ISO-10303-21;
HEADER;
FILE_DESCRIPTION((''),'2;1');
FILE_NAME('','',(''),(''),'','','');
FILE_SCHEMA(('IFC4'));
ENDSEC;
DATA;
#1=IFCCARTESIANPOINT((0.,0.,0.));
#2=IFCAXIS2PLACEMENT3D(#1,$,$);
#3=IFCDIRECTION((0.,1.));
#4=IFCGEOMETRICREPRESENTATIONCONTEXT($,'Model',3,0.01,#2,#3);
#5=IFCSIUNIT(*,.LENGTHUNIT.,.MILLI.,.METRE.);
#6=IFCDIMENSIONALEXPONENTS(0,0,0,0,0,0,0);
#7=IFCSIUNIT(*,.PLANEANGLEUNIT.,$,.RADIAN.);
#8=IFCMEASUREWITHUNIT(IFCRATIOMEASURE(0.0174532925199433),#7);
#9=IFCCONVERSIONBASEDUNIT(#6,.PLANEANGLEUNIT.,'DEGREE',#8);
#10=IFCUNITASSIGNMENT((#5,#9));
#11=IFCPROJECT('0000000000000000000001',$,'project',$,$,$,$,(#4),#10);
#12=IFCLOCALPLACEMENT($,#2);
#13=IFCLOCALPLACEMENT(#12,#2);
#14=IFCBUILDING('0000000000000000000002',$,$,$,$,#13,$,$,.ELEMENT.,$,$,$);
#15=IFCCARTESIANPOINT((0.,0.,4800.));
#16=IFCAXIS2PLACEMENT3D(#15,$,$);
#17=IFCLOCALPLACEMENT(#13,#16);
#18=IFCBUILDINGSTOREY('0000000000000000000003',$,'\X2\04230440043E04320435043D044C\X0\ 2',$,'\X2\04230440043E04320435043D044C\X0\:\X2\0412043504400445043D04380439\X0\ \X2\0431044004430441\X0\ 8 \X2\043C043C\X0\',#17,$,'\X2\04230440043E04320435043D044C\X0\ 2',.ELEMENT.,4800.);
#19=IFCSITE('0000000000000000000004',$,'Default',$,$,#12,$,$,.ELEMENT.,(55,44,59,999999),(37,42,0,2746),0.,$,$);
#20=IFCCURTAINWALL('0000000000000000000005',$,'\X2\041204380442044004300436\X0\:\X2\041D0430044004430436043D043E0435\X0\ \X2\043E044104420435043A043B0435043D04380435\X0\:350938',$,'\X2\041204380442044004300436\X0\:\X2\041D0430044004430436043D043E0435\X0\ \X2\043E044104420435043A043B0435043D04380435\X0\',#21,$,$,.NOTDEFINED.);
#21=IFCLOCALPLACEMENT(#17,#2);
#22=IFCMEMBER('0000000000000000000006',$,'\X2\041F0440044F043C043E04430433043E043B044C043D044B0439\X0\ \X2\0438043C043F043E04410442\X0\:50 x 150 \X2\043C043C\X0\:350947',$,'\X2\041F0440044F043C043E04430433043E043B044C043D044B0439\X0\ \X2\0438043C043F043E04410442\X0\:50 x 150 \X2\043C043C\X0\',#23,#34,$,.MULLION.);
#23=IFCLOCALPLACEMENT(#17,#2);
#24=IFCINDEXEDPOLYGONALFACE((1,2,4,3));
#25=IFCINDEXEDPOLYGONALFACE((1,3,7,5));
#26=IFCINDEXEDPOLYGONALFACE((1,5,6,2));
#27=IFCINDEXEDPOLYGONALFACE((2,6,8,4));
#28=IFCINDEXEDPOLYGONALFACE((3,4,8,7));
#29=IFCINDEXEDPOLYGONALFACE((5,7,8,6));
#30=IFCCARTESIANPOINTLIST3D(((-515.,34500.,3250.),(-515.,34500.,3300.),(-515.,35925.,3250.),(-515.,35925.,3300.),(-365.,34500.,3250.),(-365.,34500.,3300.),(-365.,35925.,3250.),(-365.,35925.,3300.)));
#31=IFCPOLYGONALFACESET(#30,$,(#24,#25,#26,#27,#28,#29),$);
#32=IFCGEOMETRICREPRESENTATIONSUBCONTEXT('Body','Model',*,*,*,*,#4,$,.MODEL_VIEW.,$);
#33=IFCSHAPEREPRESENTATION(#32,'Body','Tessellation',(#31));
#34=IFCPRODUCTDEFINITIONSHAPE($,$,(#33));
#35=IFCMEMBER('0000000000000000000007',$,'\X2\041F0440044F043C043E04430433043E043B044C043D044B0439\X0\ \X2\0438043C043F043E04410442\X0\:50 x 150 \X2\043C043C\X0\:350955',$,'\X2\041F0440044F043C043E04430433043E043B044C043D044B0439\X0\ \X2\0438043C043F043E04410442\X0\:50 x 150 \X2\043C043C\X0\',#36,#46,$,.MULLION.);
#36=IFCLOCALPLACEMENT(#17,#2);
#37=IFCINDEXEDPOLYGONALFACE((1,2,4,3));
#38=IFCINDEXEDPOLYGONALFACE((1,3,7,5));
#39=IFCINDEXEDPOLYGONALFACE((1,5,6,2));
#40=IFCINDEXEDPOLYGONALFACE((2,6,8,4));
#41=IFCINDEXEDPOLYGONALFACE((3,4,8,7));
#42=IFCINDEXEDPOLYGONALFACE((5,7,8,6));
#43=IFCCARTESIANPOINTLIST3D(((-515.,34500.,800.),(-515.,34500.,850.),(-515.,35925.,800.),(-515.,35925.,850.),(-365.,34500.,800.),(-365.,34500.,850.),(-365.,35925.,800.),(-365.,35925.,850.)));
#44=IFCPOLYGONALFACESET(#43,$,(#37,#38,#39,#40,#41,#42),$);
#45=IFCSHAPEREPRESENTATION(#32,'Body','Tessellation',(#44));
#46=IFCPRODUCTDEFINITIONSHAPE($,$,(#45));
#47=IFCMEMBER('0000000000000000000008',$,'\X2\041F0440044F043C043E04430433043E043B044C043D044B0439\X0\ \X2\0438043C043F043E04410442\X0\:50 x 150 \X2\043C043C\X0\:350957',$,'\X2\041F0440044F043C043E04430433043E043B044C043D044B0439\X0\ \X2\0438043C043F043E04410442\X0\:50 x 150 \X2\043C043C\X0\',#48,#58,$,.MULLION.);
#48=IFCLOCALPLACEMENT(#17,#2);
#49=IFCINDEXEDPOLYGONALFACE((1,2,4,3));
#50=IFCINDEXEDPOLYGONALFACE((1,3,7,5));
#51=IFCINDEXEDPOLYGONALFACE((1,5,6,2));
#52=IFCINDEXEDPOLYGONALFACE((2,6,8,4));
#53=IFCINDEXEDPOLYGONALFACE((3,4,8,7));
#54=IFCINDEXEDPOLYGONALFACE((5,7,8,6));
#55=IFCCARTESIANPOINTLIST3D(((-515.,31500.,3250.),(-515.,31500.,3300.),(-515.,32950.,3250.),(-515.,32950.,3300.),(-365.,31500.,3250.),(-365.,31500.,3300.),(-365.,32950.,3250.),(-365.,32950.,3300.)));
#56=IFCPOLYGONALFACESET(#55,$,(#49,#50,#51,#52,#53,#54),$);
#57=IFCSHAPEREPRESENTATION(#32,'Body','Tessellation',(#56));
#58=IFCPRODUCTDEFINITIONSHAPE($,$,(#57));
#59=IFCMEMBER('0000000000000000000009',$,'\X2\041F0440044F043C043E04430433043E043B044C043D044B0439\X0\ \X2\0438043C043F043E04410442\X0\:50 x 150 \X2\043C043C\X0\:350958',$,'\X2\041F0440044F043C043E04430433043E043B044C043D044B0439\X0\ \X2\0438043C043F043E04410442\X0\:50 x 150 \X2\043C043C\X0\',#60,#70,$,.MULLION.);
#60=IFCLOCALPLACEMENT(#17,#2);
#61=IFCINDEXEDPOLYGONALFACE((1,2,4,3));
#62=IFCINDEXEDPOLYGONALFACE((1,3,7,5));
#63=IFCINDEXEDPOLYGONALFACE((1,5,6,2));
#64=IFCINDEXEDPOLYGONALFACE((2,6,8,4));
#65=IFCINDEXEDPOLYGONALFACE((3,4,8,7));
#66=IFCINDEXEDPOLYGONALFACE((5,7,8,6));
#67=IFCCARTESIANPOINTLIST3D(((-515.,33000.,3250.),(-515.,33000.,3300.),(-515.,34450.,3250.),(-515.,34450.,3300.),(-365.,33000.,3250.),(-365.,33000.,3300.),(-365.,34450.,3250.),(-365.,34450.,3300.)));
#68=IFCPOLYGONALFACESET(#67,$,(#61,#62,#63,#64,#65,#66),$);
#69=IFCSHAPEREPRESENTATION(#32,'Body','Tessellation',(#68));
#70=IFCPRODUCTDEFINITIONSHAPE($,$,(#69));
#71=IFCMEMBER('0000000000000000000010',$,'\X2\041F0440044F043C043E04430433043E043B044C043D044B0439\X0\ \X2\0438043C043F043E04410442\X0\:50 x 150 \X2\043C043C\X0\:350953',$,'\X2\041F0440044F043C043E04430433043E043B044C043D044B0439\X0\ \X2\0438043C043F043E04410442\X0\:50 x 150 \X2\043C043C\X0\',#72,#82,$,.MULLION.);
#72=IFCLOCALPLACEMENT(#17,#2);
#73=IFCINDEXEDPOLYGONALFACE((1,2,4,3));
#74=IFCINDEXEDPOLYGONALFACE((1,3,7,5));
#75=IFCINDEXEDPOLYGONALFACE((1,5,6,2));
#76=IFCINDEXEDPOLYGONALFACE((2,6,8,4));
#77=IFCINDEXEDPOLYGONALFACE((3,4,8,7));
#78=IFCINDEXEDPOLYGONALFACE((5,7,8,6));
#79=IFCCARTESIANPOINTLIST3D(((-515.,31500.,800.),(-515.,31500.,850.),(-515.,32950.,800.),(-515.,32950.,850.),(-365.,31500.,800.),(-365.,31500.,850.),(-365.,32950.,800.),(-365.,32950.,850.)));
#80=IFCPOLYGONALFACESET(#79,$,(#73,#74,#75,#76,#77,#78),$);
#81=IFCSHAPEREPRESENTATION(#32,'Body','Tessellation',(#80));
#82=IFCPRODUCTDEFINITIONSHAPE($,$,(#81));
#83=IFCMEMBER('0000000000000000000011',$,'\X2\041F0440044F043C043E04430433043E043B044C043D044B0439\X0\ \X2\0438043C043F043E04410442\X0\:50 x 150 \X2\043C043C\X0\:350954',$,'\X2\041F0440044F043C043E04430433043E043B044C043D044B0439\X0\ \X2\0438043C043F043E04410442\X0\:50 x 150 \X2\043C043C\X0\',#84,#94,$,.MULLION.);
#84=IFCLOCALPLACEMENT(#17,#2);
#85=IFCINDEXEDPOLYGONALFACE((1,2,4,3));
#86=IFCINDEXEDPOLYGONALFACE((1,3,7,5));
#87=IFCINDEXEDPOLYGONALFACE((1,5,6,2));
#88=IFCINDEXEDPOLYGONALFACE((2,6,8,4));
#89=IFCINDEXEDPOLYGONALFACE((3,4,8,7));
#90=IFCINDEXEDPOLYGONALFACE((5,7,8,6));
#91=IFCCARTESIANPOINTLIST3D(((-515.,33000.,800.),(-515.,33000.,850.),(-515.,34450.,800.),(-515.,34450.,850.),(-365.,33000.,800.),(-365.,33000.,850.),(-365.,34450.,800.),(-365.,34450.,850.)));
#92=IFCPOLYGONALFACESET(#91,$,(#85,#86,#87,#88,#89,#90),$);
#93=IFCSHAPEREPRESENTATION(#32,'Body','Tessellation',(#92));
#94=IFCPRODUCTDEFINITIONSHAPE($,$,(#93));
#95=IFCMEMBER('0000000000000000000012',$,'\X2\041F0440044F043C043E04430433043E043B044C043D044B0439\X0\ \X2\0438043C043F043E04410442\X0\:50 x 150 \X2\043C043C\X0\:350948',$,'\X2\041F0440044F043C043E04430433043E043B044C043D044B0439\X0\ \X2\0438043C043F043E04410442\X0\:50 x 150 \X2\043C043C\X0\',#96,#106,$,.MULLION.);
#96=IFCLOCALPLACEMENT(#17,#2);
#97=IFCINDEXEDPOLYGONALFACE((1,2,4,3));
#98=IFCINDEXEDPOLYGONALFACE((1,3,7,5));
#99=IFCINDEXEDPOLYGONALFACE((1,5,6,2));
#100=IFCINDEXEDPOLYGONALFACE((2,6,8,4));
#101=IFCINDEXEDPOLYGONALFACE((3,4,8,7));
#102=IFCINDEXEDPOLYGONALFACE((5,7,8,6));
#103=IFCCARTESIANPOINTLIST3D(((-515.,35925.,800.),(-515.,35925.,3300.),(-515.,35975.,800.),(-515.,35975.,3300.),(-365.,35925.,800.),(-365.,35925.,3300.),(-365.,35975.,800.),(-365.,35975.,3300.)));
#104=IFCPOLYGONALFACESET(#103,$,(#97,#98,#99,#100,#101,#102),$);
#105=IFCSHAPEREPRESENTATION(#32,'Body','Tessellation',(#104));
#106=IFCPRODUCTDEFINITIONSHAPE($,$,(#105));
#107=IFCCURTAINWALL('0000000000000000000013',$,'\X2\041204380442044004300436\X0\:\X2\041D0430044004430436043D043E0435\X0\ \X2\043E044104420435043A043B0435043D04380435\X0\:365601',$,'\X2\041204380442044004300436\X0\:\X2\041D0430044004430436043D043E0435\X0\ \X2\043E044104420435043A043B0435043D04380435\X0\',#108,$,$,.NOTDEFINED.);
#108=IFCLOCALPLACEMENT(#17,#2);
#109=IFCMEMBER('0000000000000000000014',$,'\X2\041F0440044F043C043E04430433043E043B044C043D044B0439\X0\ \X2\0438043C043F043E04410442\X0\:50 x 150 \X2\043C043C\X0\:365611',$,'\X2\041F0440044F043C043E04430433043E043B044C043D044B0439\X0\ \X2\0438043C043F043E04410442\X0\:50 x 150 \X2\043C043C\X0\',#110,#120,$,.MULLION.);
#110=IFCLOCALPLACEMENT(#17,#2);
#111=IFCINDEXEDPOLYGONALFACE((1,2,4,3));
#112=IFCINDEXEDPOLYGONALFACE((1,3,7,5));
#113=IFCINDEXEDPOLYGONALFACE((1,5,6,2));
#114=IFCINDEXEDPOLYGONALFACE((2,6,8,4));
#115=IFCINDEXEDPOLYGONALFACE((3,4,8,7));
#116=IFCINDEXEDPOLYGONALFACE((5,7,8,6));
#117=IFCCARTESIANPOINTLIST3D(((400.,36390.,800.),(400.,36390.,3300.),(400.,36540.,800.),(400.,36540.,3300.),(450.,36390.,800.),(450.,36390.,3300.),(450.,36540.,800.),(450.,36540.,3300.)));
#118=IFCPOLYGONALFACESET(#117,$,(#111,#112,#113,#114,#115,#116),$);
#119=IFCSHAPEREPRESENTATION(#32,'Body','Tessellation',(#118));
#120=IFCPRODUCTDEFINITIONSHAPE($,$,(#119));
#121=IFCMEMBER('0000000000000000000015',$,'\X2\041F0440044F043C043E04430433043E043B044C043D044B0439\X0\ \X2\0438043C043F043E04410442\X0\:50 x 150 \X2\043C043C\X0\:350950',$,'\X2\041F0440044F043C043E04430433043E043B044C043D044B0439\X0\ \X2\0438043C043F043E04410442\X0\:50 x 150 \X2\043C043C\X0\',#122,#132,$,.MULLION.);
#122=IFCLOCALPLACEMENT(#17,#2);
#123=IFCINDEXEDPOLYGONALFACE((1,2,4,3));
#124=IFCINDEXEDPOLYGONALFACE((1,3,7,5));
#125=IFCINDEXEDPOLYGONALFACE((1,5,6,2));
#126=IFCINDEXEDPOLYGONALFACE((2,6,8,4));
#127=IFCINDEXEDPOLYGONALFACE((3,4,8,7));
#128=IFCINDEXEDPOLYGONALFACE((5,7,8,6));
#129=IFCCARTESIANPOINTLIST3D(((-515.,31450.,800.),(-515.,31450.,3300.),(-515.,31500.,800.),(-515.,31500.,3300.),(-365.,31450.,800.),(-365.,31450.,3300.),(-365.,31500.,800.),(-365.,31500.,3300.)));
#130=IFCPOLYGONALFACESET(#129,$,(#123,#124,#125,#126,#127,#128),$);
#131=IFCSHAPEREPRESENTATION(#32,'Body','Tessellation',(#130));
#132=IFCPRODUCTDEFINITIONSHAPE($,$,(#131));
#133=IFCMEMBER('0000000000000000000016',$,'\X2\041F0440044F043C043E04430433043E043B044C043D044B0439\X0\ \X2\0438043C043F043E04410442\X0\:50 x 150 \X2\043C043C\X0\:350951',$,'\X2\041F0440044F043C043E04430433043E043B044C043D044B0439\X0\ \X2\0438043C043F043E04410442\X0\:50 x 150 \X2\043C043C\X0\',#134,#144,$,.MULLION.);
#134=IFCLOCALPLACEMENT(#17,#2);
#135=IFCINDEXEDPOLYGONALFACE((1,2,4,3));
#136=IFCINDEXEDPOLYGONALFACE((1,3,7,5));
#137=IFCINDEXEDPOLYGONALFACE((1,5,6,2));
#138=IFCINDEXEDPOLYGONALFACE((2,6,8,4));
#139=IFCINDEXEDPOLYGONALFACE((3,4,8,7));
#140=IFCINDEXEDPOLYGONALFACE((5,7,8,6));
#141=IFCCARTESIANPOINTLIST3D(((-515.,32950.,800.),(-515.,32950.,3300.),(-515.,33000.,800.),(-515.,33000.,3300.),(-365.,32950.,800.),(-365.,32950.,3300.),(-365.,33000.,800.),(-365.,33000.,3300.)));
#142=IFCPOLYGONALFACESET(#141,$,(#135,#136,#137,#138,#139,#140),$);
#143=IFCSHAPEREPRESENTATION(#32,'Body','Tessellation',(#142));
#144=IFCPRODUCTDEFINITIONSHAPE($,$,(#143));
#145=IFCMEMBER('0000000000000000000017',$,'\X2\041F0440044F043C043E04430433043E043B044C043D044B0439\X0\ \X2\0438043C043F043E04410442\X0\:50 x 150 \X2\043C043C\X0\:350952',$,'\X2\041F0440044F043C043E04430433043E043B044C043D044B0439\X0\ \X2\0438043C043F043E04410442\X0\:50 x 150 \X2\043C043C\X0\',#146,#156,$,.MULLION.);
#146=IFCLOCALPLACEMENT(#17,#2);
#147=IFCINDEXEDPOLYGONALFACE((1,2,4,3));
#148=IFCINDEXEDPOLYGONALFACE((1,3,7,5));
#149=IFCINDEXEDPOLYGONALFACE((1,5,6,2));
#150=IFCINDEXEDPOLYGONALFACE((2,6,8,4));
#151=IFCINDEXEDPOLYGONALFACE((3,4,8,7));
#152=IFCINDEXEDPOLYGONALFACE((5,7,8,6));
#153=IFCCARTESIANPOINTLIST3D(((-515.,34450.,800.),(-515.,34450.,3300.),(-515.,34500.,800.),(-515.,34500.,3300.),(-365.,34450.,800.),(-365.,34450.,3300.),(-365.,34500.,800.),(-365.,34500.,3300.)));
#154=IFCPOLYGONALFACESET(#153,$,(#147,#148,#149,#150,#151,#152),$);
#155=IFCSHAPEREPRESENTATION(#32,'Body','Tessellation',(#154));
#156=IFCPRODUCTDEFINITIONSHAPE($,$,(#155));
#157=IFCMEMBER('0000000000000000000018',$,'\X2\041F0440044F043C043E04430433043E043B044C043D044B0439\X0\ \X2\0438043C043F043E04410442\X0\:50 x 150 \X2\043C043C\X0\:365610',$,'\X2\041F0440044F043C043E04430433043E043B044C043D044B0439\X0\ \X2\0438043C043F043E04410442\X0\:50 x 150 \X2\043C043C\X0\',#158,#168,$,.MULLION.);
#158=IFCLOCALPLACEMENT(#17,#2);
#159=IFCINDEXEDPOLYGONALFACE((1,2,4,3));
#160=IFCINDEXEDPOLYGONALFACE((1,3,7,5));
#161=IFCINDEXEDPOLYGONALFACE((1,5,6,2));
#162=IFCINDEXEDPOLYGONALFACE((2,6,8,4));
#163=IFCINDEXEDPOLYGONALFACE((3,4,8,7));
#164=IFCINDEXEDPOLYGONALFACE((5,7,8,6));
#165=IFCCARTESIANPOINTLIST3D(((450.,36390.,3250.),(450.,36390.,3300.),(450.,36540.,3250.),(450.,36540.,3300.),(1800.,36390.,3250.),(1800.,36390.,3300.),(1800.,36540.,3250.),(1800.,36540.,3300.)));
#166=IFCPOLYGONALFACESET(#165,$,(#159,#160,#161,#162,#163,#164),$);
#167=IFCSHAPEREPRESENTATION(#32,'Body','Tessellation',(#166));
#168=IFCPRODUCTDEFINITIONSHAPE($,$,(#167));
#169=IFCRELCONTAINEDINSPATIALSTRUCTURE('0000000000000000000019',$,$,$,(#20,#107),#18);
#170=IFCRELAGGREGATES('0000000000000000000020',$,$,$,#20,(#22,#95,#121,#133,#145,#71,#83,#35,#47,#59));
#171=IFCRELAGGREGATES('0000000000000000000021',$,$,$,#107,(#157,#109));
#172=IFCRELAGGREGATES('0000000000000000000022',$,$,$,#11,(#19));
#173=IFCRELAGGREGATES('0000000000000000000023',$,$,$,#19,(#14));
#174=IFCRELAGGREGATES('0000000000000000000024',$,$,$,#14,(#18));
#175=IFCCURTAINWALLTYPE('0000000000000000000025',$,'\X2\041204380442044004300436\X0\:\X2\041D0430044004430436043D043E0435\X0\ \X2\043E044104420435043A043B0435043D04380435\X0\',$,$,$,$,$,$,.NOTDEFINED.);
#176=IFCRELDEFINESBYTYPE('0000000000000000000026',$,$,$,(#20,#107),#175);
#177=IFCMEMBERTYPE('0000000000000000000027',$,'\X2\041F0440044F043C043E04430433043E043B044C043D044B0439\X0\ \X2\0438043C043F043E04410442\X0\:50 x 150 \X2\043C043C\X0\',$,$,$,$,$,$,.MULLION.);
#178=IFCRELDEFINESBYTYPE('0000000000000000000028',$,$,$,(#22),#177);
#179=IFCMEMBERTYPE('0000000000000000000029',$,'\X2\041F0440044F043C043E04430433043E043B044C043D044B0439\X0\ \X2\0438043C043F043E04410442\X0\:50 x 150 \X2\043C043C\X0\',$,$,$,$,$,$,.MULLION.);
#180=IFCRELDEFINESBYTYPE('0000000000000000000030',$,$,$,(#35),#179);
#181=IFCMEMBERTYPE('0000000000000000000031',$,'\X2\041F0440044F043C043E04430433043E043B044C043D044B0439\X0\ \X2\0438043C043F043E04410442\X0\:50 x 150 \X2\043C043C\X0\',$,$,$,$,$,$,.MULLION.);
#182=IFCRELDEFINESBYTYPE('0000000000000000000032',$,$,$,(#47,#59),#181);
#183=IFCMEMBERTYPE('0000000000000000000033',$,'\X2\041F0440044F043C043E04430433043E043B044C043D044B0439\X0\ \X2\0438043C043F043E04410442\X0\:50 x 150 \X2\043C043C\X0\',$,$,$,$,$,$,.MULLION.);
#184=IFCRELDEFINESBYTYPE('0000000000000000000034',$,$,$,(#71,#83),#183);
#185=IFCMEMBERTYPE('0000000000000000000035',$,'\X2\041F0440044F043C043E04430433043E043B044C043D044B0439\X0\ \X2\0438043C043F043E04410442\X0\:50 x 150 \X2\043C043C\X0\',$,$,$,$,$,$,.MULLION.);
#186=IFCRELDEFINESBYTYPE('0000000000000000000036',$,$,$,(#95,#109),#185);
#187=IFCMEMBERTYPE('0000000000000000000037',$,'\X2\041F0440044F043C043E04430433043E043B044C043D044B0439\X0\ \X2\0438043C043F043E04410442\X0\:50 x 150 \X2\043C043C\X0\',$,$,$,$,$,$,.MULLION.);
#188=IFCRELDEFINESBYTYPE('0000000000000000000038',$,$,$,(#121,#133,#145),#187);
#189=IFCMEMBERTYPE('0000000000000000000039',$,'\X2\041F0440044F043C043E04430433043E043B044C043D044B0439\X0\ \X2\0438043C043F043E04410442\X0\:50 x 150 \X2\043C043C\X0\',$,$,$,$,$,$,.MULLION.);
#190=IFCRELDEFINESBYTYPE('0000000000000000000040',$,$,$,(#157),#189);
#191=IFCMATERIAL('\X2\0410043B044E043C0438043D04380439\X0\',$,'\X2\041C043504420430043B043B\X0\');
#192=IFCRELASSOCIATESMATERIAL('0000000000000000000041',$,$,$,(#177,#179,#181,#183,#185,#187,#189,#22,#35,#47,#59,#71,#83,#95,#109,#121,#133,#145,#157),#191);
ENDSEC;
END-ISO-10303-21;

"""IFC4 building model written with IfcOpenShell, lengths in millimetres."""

from ifc_helpers import new_model, entity, si_unit, converted_unit, direction, frame, origin, origin_2d_with_axis, place, context, subcontext, project, spatial, rectangle, extrude, source, transform, mapped, material, material_profile, profile_set, profile_usage, type_object, type_shapes, element, aggregate, save


model = new_model("IFC4")

# Units and contexts
model_context = context("Model", 3, precision=0.01, world=origin(), true_north=direction((0.0, 1.0)))
body_context = subcontext(model_context, "Body", "Model", "MODEL_VIEW")
ifc_project = project(units=[si_unit("LENGTHUNIT", "METRE", prefix="MILLI"), converted_unit("PLANEANGLEUNIT", "DEGREE", entity("IfcRatioMeasure", 0.0174532925199433), si_unit("PLANEANGLEUNIT", "RADIAN"), dimensions=[0, 0, 0, 0, 0, 0, 0])], contexts=[model_context])

# Site, building, storey
site_placement = place(None, origin())
site = spatial("IfcSite", under=ifc_project, at=site_placement, Name="Default", CompositionType="ELEMENT", RefLatitude=(55, 44, 59, 999999), RefLongitude=(37, 42, 0, 2746), RefElevation=0.0)
building_placement = place(site_placement, origin())
building = spatial("IfcBuilding", under=site, at=building_placement, CompositionType="ELEMENT")
storey_placement = place(building_placement, frame((0.0, 0.0, 4800.0)))
storey = spatial("IfcBuildingStorey", under=building, at=storey_placement, Name="Уровень 2", ObjectType="Уровень:Верхний брус 8 мм", LongName="Уровень 2", CompositionType="ELEMENT", Elevation=4800.0)

# Curtain wall, members
curtain_wall_type = type_object("IfcCurtainWallType", Name="Витраж:Наружное остекление", PredefinedType="NOTDEFINED")
curtain_wall_1_placement = place(storey_placement, frame((0.0, 0.0, -4800.0)))
curtain_wall_1 = element("IfcCurtainWall", 1, at=curtain_wall_1_placement, inside=storey, type_object=curtain_wall_type, Name="Витраж:Наружное остекление:350938", ObjectType="Витраж:Наружное остекление", PredefinedType="NOTDEFINED")
ifc_material_1 = material(Name="Алюминий", Category="Металл")
ifc_material_profile = material_profile(ifc_material_1, rectangle(XDim=150.0, YDim=50.0, at=origin_2d_with_axis()), Name="50 x 150 мм")
ifc_profile_set = profile_set([ifc_material_profile], Name="50 x 150 мм")
ifc_profile_usage_1 = profile_usage(ifc_profile_set)
member_type_1 = type_object("IfcMemberType", Name="Прямоугольный импост:50 x 150 мм", PredefinedType="MULLION", material=ifc_profile_set)
shared_shape_1 = source(origin(), body_context, "Body", "SweptSolid", [
    extrude(rectangle(XDim=150.0, YDim=50.0, at=origin_2d_with_axis()), frame((-25.0, 0.0, -1425.0), z_axis=(0.0, 0.0, 1.0), x_axis=(0.0, -1.0, 0.0)), (0.0, 0.0, 1.0), 1425.0),
])
type_shapes(member_type_1, [shared_shape_1])
member_1_placement = place(storey_placement, frame((-440.0, 35925.0, 3300.0), z_axis=(0.0, 1.0, 0.0), x_axis=(0.0, 0.0, 1.0)))
member_1 = element("IfcMember", 2, at=member_1_placement, type_object=member_type_1, material=ifc_profile_usage_1, Name="Прямоугольный импост:50 x 150 мм:350947", ObjectType="Прямоугольный импост:50 x 150 мм", PredefinedType="MULLION", context=body_context, shape_type="MappedRepresentation", body=[
    mapped(shared_shape_1, transform((0.0, 0.0, 0.0), scale=1.0)),
])
ifc_profile_usage_2 = profile_usage(ifc_profile_set)
member_type_2 = type_object("IfcMemberType", Name="Прямоугольный импост:50 x 150 мм", PredefinedType="MULLION", material=ifc_profile_set)
shared_shape_2 = source(origin(), body_context, "Body", "SweptSolid", [
    extrude(rectangle(XDim=150.0, YDim=50.0, at=origin_2d_with_axis()), frame((-25.0, 0.0, -1425.0), z_axis=(0.0, 0.0, 1.0), x_axis=(0.0, -1.0, 0.0)), (0.0, 0.0, 1.0), 1425.0),
])
type_shapes(member_type_2, [shared_shape_2])
member_2_placement = place(storey_placement, frame((-440.0, 34500.0, 800.0), z_axis=(0.0, -1.0, 0.0), x_axis=(0.0, 0.0, -1.0)))
member_2 = element("IfcMember", 3, at=member_2_placement, type_object=member_type_2, material=ifc_profile_usage_2, Name="Прямоугольный импост:50 x 150 мм:350955", ObjectType="Прямоугольный импост:50 x 150 мм", PredefinedType="MULLION", context=body_context, shape_type="MappedRepresentation", body=[
    mapped(shared_shape_2, transform((0.0, 0.0, 0.0), scale=1.0)),
])
ifc_profile_usage_3 = profile_usage(ifc_profile_set)
member_type_3 = type_object("IfcMemberType", Name="Прямоугольный импост:50 x 150 мм", PredefinedType="MULLION", material=ifc_profile_set)
shared_shape_3 = source(origin(), body_context, "Body", "SweptSolid", [
    extrude(rectangle(XDim=150.0, YDim=50.0, at=origin_2d_with_axis()), frame((-25.0, 0.0, -1450.0), z_axis=(0.0, 0.0, 1.0), x_axis=(0.0, -1.0, 0.0)), (0.0, 0.0, 1.0), 1450.0),
])
type_shapes(member_type_3, [shared_shape_3])
member_3_placement = place(storey_placement, frame((-440.0, 32950.0, 3300.0), z_axis=(0.0, 1.0, 0.0), x_axis=(0.0, 0.0, 1.0)))
member_3 = element("IfcMember", 4, at=member_3_placement, type_object=member_type_3, material=ifc_profile_usage_3, Name="Прямоугольный импост:50 x 150 мм:350957", ObjectType="Прямоугольный импост:50 x 150 мм", PredefinedType="MULLION", context=body_context, shape_type="MappedRepresentation", body=[
    mapped(shared_shape_3, transform((0.0, 0.0, 0.0), scale=1.0)),
])
ifc_profile_usage_4 = profile_usage(ifc_profile_set)
member_4_placement = place(storey_placement, frame((-440.0, 34450.0, 3300.0), z_axis=(0.0, 1.0, 0.0), x_axis=(0.0, 0.0, 1.0)))
member_4 = element("IfcMember", 5, at=member_4_placement, type_object=member_type_3, material=ifc_profile_usage_4, Name="Прямоугольный импост:50 x 150 мм:350958", ObjectType="Прямоугольный импост:50 x 150 мм", PredefinedType="MULLION", context=body_context, shape_type="MappedRepresentation", body=[
    mapped(shared_shape_3, transform((0.0, 0.0, 0.0), scale=1.0)),
])
ifc_profile_usage_5 = profile_usage(ifc_profile_set)
member_type_4 = type_object("IfcMemberType", Name="Прямоугольный импост:50 x 150 мм", PredefinedType="MULLION", material=ifc_profile_set)
shared_shape_4 = source(origin(), body_context, "Body", "SweptSolid", [
    extrude(rectangle(XDim=150.0, YDim=50.0, at=origin_2d_with_axis()), frame((-25.0, 0.0, -1450.0), z_axis=(0.0, 0.0, 1.0), x_axis=(0.0, -1.0, 0.0)), (0.0, 0.0, 1.0), 1450.0),
])
type_shapes(member_type_4, [shared_shape_4])
member_5_placement = place(storey_placement, frame((-440.0, 31500.0, 800.0), z_axis=(0.0, -1.0, 0.0), x_axis=(0.0, 0.0, -1.0)))
member_5 = element("IfcMember", 6, at=member_5_placement, type_object=member_type_4, material=ifc_profile_usage_5, Name="Прямоугольный импост:50 x 150 мм:350953", ObjectType="Прямоугольный импост:50 x 150 мм", PredefinedType="MULLION", context=body_context, shape_type="MappedRepresentation", body=[
    mapped(shared_shape_4, transform((0.0, 0.0, 0.0), scale=1.0)),
])
ifc_profile_usage_6 = profile_usage(ifc_profile_set)
member_6_placement = place(storey_placement, frame((-440.0, 33000.0, 800.0), z_axis=(0.0, -1.0, 0.0), x_axis=(0.0, 0.0, -1.0)))
member_6 = element("IfcMember", 7, at=member_6_placement, type_object=member_type_4, material=ifc_profile_usage_6, Name="Прямоугольный импост:50 x 150 мм:350954", ObjectType="Прямоугольный импост:50 x 150 мм", PredefinedType="MULLION", context=body_context, shape_type="MappedRepresentation", body=[
    mapped(shared_shape_4, transform((0.0, 0.0, 0.0), scale=1.0)),
])
ifc_profile_usage_7 = profile_usage(ifc_profile_set)
member_type_5 = type_object("IfcMemberType", Name="Прямоугольный импост:50 x 150 мм", PredefinedType="MULLION", material=ifc_profile_set)
shared_shape_5 = source(origin(), body_context, "Body", "SweptSolid", [
    extrude(rectangle(XDim=150.0, YDim=50.0, at=origin_2d_with_axis()), frame((-25.0, 0.0, -2500.0), z_axis=(0.0, 0.0, 1.0), x_axis=(0.0, -1.0, 0.0)), (0.0, 0.0, 1.0), 2500.0),
])
type_shapes(member_type_5, [shared_shape_5])
member_7_placement = place(storey_placement, frame((-440.0, 35975.0, 800.0), z_axis=(0.0, 0.0, -1.0), x_axis=(0.0, 1.0, 0.0)))
member_7 = element("IfcMember", 8, at=member_7_placement, type_object=member_type_5, material=ifc_profile_usage_7, Name="Прямоугольный импост:50 x 150 мм:350948", ObjectType="Прямоугольный импост:50 x 150 мм", PredefinedType="MULLION", context=body_context, shape_type="MappedRepresentation", body=[
    mapped(shared_shape_5, transform((0.0, 0.0, 0.0), scale=1.0)),
])

# Curtain wall, member
curtain_wall_2_placement = place(storey_placement, frame((0.0, 0.0, -4800.0)))
curtain_wall_2 = element("IfcCurtainWall", 9, at=curtain_wall_2_placement, inside=storey, type_object=curtain_wall_type, Name="Витраж:Наружное остекление:365601", ObjectType="Витраж:Наружное остекление", PredefinedType="NOTDEFINED")
ifc_profile_usage_8 = profile_usage(ifc_profile_set)
member_8_placement = place(storey_placement, frame((400.0, 36465.0, 800.0), z_axis=(0.0, 0.0, -1.0), x_axis=(-1.0, 0.0, 0.0)))
member_8 = element("IfcMember", 10, at=member_8_placement, type_object=member_type_5, material=ifc_profile_usage_8, Name="Прямоугольный импост:50 x 150 мм:365611", ObjectType="Прямоугольный импост:50 x 150 мм", PredefinedType="MULLION", context=body_context, shape_type="MappedRepresentation", body=[
    mapped(shared_shape_5, transform((0.0, 0.0, 0.0), scale=1.0)),
])

# Members
ifc_profile_usage_9 = profile_usage(ifc_profile_set)
member_type_6 = type_object("IfcMemberType", Name="Прямоугольный импост:50 x 150 мм", PredefinedType="MULLION", material=ifc_profile_set)
shared_shape_6 = source(origin(), body_context, "Body", "SweptSolid", [
    extrude(rectangle(XDim=150.0, YDim=50.0, at=origin_2d_with_axis()), frame((0.0, 0.0, -2500.0), z_axis=(0.0, 0.0, 1.0), x_axis=(0.0, -1.0, 0.0)), (0.0, 0.0, 1.0), 2500.0),
])
type_shapes(member_type_6, [shared_shape_6])
member_9_placement = place(storey_placement, frame((-440.0, 31475.0, 800.0), z_axis=(0.0, 0.0, -1.0), x_axis=(0.0, 1.0, 0.0)))
member_9 = element("IfcMember", 11, at=member_9_placement, type_object=member_type_6, material=ifc_profile_usage_9, Name="Прямоугольный импост:50 x 150 мм:350950", ObjectType="Прямоугольный импост:50 x 150 мм", PredefinedType="MULLION", context=body_context, shape_type="MappedRepresentation", body=[
    mapped(shared_shape_6, transform((0.0, 0.0, 0.0), scale=1.0)),
])
ifc_profile_usage_10 = profile_usage(ifc_profile_set)
member_10_placement = place(storey_placement, frame((-440.0, 32975.0, 800.0), z_axis=(0.0, 0.0, -1.0), x_axis=(0.0, 1.0, 0.0)))
member_10 = element("IfcMember", 12, at=member_10_placement, type_object=member_type_6, material=ifc_profile_usage_10, Name="Прямоугольный импост:50 x 150 мм:350951", ObjectType="Прямоугольный импост:50 x 150 мм", PredefinedType="MULLION", context=body_context, shape_type="MappedRepresentation", body=[
    mapped(shared_shape_6, transform((0.0, 0.0, 0.0), scale=1.0)),
])
ifc_profile_usage_11 = profile_usage(ifc_profile_set)
member_11_placement = place(storey_placement, frame((-440.0, 34475.0, 800.0), z_axis=(0.0, 0.0, -1.0), x_axis=(0.0, 1.0, 0.0)))
member_11 = element("IfcMember", 13, at=member_11_placement, type_object=member_type_6, material=ifc_profile_usage_11, Name="Прямоугольный импост:50 x 150 мм:350952", ObjectType="Прямоугольный импост:50 x 150 мм", PredefinedType="MULLION", context=body_context, shape_type="MappedRepresentation", body=[
    mapped(shared_shape_6, transform((0.0, 0.0, 0.0), scale=1.0)),
])
ifc_profile_usage_12 = profile_usage(ifc_profile_set)
member_type_7 = type_object("IfcMemberType", Name="Прямоугольный импост:50 x 150 мм", PredefinedType="MULLION", material=ifc_profile_set)
shared_shape_7 = source(origin(), body_context, "Body", "SweptSolid", [
    extrude(rectangle(XDim=150.0, YDim=50.0, at=origin_2d_with_axis()), frame((-25.0, 0.0, -1350.0), z_axis=(0.0, 0.0, 1.0), x_axis=(0.0, -1.0, 0.0)), (0.0, 0.0, 1.0), 1350.0),
])
type_shapes(member_type_7, [shared_shape_7])
member_12_placement = place(storey_placement, frame((450.0, 36465.0, 3300.0), z_axis=(-1.0, 0.0, 0.0), x_axis=(0.0, 0.0, 1.0)))
member_12 = element("IfcMember", 14, at=member_12_placement, type_object=member_type_7, material=ifc_profile_usage_12, Name="Прямоугольный импост:50 x 150 мм:365610", ObjectType="Прямоугольный импост:50 x 150 мм", PredefinedType="MULLION", context=body_context, shape_type="MappedRepresentation", body=[
    mapped(shared_shape_7, transform((0.0, 0.0, 0.0), scale=1.0)),
])

aggregate(curtain_wall_1, [member_1, member_7, member_9, member_10, member_11, member_5, member_6, member_2, member_3, member_4])
aggregate(curtain_wall_2, [member_12, member_8])

save(model, "model.ifc")
